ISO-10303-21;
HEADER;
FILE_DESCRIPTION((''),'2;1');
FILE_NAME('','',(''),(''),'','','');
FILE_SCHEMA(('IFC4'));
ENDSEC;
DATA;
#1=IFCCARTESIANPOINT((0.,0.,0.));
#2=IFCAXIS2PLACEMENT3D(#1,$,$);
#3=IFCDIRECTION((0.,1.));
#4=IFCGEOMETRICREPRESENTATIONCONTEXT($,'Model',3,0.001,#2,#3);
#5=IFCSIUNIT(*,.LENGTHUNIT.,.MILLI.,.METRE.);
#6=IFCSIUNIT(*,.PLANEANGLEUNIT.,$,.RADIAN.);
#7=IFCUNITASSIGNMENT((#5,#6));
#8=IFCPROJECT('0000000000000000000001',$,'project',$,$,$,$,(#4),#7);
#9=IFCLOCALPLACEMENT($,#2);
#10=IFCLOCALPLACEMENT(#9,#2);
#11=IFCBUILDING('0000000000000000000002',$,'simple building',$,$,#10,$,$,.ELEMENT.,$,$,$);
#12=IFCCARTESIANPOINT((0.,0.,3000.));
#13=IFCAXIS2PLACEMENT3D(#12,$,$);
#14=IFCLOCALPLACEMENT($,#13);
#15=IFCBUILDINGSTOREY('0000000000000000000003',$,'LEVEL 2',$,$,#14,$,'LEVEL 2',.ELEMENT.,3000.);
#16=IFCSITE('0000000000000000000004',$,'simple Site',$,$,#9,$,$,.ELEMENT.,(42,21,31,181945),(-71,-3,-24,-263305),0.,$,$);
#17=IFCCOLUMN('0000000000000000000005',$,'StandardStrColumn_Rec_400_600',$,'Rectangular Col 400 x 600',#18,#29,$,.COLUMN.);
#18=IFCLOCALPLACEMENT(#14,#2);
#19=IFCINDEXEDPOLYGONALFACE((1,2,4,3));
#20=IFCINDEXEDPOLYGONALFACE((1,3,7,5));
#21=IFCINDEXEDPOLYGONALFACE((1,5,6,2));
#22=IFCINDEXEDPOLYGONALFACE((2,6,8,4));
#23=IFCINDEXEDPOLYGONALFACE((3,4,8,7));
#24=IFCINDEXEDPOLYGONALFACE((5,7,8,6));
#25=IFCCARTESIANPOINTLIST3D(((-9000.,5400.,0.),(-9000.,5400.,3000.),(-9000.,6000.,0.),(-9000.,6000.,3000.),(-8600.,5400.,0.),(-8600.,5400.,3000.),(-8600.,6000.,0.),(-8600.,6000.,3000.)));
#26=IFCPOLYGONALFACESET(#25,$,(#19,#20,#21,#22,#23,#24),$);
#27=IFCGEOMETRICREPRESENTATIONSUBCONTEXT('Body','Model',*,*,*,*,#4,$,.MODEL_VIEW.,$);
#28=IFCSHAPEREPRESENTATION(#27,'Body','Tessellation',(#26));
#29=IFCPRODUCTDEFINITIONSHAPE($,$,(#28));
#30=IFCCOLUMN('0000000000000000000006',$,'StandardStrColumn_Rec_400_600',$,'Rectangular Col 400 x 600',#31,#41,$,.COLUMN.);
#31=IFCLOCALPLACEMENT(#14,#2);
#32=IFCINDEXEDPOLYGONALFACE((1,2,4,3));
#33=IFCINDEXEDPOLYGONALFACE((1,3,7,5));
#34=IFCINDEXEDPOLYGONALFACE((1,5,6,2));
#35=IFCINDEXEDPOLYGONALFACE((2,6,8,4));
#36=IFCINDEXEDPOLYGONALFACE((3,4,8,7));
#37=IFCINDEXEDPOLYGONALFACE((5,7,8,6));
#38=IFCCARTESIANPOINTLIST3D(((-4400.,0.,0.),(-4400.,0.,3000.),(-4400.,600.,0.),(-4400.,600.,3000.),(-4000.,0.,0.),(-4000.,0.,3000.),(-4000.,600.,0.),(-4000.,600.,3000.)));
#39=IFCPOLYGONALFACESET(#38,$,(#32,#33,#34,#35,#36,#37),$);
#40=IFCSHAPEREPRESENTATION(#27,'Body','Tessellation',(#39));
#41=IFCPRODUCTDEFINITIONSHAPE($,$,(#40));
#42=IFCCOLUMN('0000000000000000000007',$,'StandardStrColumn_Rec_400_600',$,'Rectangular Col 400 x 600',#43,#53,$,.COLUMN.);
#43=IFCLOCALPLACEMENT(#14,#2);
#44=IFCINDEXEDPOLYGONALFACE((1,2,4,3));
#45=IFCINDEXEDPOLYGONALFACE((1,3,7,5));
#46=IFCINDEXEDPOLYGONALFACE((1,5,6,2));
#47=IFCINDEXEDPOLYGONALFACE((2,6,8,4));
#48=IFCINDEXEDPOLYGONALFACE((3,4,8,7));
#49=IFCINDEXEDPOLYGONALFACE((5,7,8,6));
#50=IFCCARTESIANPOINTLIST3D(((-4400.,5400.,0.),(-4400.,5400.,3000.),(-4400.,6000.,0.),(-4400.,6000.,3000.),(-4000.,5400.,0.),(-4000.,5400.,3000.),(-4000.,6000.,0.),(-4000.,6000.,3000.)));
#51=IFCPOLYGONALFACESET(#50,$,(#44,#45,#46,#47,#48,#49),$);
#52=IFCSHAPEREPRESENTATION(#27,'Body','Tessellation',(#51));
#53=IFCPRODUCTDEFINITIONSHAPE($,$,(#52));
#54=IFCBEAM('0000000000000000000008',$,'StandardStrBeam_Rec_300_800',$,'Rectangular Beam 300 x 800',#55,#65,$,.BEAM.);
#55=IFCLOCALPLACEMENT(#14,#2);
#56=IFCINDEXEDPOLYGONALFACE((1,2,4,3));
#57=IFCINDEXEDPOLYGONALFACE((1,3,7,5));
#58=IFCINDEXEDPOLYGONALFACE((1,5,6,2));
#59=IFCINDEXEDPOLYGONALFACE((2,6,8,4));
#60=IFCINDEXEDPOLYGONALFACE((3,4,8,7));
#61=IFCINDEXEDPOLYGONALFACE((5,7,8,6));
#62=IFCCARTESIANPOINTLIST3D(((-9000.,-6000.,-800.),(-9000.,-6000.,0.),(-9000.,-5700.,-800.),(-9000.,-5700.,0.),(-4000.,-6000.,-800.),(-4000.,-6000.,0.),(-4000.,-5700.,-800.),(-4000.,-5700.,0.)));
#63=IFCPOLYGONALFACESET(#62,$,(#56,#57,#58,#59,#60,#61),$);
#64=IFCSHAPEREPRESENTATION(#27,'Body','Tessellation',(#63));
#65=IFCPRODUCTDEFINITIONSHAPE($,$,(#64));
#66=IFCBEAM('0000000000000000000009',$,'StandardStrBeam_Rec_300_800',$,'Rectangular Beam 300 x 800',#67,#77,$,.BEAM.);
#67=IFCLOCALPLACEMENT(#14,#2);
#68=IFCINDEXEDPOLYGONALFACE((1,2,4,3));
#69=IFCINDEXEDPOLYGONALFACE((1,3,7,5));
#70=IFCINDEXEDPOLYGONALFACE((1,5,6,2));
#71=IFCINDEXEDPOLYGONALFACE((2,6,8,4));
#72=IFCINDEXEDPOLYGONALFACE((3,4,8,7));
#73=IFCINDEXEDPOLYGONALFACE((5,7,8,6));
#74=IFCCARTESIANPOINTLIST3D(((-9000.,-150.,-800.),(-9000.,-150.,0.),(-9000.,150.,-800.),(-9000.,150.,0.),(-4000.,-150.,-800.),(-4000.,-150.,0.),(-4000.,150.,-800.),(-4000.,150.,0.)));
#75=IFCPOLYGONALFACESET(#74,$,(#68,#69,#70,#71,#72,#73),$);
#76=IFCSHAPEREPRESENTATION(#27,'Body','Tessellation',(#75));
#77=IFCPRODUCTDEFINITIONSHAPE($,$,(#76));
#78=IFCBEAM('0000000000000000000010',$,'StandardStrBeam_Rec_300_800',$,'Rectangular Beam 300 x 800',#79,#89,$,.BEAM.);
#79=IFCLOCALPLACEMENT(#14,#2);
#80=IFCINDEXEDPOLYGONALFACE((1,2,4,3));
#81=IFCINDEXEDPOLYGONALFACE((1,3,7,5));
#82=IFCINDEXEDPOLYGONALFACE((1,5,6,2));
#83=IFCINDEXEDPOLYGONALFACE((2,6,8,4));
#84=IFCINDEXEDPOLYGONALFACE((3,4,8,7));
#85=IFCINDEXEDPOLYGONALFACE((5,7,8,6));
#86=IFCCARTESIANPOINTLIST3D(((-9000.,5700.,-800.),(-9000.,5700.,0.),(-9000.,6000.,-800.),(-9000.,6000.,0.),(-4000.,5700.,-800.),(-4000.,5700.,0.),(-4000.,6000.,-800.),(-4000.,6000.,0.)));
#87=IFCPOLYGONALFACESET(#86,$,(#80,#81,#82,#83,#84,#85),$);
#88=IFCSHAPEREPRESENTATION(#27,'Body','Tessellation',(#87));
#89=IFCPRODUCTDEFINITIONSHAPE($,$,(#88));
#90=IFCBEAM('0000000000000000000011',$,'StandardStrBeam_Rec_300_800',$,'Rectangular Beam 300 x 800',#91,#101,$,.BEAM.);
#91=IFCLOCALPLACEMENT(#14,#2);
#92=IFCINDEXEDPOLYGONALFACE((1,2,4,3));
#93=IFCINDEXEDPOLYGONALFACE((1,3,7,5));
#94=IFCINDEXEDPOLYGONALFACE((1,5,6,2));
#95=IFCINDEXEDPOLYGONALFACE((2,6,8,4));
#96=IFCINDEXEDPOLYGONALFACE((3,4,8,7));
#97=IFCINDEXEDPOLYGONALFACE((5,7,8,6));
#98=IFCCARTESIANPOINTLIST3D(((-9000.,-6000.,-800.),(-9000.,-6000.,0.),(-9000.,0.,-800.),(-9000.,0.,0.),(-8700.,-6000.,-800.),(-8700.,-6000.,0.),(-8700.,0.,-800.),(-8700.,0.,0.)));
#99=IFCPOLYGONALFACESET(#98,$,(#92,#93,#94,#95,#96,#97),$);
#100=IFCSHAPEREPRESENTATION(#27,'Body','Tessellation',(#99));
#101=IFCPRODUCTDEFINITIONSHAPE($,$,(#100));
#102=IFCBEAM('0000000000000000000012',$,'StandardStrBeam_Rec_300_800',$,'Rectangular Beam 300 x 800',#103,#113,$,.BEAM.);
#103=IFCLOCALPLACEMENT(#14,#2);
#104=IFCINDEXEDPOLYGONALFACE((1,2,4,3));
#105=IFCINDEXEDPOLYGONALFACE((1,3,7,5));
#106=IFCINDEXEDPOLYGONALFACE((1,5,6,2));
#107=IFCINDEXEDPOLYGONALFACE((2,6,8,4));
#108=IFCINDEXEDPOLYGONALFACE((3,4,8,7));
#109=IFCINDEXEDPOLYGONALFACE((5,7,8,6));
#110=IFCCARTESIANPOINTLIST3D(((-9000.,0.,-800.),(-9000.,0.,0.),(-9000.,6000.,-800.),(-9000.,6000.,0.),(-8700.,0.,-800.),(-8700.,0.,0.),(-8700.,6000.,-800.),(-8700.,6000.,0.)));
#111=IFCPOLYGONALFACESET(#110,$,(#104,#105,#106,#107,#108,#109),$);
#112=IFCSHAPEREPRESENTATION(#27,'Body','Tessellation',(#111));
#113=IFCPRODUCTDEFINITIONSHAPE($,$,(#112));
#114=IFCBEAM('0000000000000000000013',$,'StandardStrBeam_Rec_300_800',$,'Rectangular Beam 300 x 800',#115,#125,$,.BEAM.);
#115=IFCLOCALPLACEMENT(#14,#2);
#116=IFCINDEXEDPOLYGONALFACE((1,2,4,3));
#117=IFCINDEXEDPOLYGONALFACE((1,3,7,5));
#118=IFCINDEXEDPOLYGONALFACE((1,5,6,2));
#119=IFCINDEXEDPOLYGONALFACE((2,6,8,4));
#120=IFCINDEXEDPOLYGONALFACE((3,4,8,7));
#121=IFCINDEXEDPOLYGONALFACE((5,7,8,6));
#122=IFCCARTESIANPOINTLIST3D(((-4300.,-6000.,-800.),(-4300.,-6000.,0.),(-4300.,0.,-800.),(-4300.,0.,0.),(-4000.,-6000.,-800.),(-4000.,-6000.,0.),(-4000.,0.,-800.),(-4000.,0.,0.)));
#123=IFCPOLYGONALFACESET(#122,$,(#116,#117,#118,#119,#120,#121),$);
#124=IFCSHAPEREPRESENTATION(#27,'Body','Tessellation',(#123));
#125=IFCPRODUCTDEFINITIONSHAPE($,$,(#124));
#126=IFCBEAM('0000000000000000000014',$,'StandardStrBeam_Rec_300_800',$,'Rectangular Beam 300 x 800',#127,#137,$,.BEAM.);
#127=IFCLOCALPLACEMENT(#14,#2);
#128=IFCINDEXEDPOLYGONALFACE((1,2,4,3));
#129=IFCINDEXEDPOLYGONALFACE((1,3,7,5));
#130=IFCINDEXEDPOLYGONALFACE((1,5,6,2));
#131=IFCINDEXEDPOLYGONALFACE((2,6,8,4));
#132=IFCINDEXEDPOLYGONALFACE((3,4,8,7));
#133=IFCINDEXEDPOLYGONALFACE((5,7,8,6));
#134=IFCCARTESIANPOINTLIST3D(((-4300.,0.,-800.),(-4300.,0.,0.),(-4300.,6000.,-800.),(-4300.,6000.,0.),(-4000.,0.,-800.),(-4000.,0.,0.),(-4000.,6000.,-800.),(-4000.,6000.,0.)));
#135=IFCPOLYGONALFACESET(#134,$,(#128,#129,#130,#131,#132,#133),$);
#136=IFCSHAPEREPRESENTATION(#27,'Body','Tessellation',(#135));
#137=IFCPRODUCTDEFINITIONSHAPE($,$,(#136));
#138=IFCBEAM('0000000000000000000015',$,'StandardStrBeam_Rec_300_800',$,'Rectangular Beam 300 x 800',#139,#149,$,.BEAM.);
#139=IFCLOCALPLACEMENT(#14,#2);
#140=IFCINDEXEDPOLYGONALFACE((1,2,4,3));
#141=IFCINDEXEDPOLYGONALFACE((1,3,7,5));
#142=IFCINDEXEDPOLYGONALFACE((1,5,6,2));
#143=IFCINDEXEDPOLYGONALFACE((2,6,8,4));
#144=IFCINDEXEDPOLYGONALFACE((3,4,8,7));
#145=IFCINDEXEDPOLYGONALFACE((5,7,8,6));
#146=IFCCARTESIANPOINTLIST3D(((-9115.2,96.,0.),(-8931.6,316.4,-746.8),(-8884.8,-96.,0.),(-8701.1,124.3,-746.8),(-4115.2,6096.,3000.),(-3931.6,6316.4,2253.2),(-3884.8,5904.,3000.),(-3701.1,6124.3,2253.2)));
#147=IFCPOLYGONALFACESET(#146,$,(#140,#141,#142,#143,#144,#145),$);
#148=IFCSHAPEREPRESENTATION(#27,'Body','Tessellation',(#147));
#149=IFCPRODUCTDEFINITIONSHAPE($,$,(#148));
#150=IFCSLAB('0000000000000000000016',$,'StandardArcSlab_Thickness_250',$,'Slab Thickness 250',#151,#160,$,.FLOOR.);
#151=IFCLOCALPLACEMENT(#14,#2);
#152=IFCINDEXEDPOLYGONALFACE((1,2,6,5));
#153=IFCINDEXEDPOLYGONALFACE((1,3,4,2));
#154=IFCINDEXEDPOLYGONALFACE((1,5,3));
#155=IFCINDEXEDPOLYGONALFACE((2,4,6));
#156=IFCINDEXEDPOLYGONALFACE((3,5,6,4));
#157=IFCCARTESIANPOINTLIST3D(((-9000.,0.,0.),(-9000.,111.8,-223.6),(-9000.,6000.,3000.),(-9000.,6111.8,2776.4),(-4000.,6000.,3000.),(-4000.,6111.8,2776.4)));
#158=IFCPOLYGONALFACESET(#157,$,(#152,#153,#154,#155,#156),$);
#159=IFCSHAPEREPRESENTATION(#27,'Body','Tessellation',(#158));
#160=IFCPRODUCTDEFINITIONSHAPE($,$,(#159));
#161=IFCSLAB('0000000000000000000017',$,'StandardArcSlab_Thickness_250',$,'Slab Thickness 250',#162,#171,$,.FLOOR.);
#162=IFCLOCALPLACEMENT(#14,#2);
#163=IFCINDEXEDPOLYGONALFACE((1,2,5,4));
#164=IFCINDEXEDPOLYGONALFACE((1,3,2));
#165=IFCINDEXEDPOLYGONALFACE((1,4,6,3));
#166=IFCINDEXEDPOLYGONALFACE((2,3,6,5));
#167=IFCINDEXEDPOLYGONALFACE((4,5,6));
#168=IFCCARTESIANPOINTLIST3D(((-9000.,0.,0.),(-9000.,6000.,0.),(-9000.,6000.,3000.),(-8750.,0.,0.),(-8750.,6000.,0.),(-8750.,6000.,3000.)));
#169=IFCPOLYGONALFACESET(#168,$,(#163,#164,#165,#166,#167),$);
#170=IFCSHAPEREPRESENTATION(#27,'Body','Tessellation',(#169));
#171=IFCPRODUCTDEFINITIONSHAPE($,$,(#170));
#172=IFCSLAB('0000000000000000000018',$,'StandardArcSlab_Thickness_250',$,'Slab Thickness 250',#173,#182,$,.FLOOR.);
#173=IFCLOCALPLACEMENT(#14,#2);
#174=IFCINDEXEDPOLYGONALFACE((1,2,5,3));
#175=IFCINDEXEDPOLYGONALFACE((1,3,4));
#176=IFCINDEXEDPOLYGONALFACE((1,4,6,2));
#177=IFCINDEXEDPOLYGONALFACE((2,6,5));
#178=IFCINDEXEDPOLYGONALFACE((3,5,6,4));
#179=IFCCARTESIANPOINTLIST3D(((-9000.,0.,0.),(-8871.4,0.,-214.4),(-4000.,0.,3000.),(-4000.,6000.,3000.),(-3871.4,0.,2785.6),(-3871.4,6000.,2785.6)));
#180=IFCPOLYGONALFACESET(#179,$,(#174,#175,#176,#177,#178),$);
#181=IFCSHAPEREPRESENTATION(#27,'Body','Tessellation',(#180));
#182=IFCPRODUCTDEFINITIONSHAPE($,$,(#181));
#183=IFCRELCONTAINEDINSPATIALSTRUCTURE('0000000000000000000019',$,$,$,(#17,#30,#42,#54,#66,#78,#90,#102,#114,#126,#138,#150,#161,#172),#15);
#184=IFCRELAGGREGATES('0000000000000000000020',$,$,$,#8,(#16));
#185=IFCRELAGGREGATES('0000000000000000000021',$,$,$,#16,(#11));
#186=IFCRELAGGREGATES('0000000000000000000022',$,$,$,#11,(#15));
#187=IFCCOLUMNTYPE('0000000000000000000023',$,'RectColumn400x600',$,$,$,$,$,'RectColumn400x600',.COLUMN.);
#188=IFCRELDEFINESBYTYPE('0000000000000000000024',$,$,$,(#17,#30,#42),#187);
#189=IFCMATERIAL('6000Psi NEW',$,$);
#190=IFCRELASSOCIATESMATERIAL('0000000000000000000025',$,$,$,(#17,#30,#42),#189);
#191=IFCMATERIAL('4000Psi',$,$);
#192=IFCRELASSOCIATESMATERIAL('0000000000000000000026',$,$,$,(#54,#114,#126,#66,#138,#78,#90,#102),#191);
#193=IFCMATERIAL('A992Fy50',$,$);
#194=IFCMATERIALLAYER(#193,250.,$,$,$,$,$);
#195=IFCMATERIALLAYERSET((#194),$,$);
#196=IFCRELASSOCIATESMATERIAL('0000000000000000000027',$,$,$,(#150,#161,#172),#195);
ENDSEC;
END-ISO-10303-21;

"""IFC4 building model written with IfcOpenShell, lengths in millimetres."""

from ifc_helpers import new_model, si_unit, direction, frame, origin, origin_with_axes, origin_2d_with_axis, place, context, subcontext, project, spatial, polyline, rectangle, outline, extrude, material, layer, layer_set, layer_usage, material_profile, profile_set, profile_usage, type_object, element, save


model = new_model("IFC4")

# Units and contexts
model_context = context("Model", 3, precision=0.001, world=origin(), true_north=direction((0.0, 1.0)))
body_context = subcontext(model_context, "Body", "Model", "MODEL_VIEW")
ifc_project = project(units=[si_unit("LENGTHUNIT", "METRE", prefix="MILLI"), si_unit("PLANEANGLEUNIT", "RADIAN")], contexts=[model_context])

# Site, building, storey
site_placement = place(None, origin())
site = spatial("IfcSite", under=ifc_project, at=site_placement, Name="simple Site", CompositionType="ELEMENT", RefLatitude=(42, 21, 31, 181945), RefLongitude=(-71, -3, -24, -263305), RefElevation=0.0)
building_placement = place(site_placement, origin())
building = spatial("IfcBuilding", under=site, at=building_placement, Name="simple building", CompositionType="ELEMENT")
storey_placement = place(None, frame((0.0, 0.0, 3000.0)))
storey = spatial("IfcBuildingStorey", under=building, at=storey_placement, Name="LEVEL 2", LongName="LEVEL 2", CompositionType="ELEMENT", Elevation=3000.0)

# Columns
ifc_material_1 = material(Name="6000Psi NEW")
ifc_material_profile_1 = material_profile(ifc_material_1, rectangle(XDim=400.0, YDim=600.0, at=origin_2d_with_axis()))
ifc_profile_set_1 = profile_set([ifc_material_profile_1])
ifc_profile_usage_1 = profile_usage(ifc_profile_set_1, cardinal=1)
column_type = type_object("IfcColumnType", Name="RectColumn400x600", ElementType="RectColumn400x600", PredefinedType="COLUMN")
column_1_placement = place(None, frame((-8800.0, 5700.0, 3000.0), z_axis=(0.0, 0.0, 1.0), x_axis=(1.0, 0.0, 0.0)))
element("IfcColumn", 1, at=column_1_placement, inside=storey, type_object=column_type, material=ifc_profile_usage_1, Name="StandardStrColumn_Rec_400_600", ObjectType="Rectangular Col 400 x 600", PredefinedType="COLUMN", context=body_context, shape_type="SweptSolid", body=[
    extrude(rectangle(XDim=400.0, YDim=600.0, at=origin_2d_with_axis()), origin_with_axes(), (0.0, 0.0, 1.0), 3000.0),
])
ifc_profile_usage_2 = profile_usage(ifc_profile_set_1, cardinal=9)
column_2_placement = place(None, frame((-4200.0, 300.0, 3000.0), z_axis=(0.0, 0.0, 1.0), x_axis=(1.0, 0.0, 0.0)))
element("IfcColumn", 2, at=column_2_placement, inside=storey, type_object=column_type, material=ifc_profile_usage_2, Name="StandardStrColumn_Rec_400_600", ObjectType="Rectangular Col 400 x 600", PredefinedType="COLUMN", context=body_context, shape_type="SweptSolid", body=[
    extrude(rectangle(XDim=400.0, YDim=600.0, at=origin_2d_with_axis()), origin_with_axes(), (0.0, 0.0, 1.0), 3000.0),
])
ifc_profile_usage_3 = profile_usage(ifc_profile_set_1, cardinal=3)
column_3_placement = place(None, frame((-4200.0, 5700.0, 3000.0), z_axis=(0.0, 0.0, 1.0), x_axis=(1.0, 0.0, 0.0)))
element("IfcColumn", 3, at=column_3_placement, inside=storey, type_object=column_type, material=ifc_profile_usage_3, Name="StandardStrColumn_Rec_400_600", ObjectType="Rectangular Col 400 x 600", PredefinedType="COLUMN", context=body_context, shape_type="SweptSolid", body=[
    extrude(rectangle(XDim=400.0, YDim=600.0, at=origin_2d_with_axis()), origin_with_axes(), (0.0, 0.0, 1.0), 3000.0),
])

# Beams
ifc_material_2 = material(Name="4000Psi")
ifc_material_profile_2 = material_profile(ifc_material_2, rectangle(XDim=300.0, YDim=800.0, at=origin_2d_with_axis()))
ifc_profile_set_2 = profile_set([ifc_material_profile_2])
ifc_profile_usage_4 = profile_usage(ifc_profile_set_2, cardinal=9)
beam_1_placement = place(None, frame((-9000.0, -5850.0, 2600.0), z_axis=(1.0, 0.0, 0.0), x_axis=(0.0, -1.0, 0.0)))
element("IfcBeam", 4, at=beam_1_placement, inside=storey, material=ifc_profile_usage_4, Name="StandardStrBeam_Rec_300_800", ObjectType="Rectangular Beam 300 x 800", PredefinedType="BEAM", context=body_context, shape_type="SweptSolid", body=[
    extrude(rectangle(XDim=300.0, YDim=800.0, at=origin_2d_with_axis()), origin_with_axes(), (0.0, 0.0, 1.0), 5000.0),
])
ifc_profile_usage_5 = profile_usage(ifc_profile_set_2, cardinal=8)
beam_2_placement = place(None, frame((-9000.0, 0.0, 2600.0), z_axis=(1.0, 0.0, 0.0), x_axis=(0.0, -1.0, 0.0)))
element("IfcBeam", 5, at=beam_2_placement, inside=storey, material=ifc_profile_usage_5, Name="StandardStrBeam_Rec_300_800", ObjectType="Rectangular Beam 300 x 800", PredefinedType="BEAM", context=body_context, shape_type="SweptSolid", body=[
    extrude(rectangle(XDim=300.0, YDim=800.0, at=origin_2d_with_axis()), origin_with_axes(), (0.0, 0.0, 1.0), 5000.0),
])
ifc_profile_usage_6 = profile_usage(ifc_profile_set_2, cardinal=7)
beam_3_placement = place(None, frame((-9000.0, 5850.0, 2600.0), z_axis=(1.0, 0.0, 0.0), x_axis=(0.0, -1.0, 0.0)))
element("IfcBeam", 6, at=beam_3_placement, inside=storey, material=ifc_profile_usage_6, Name="StandardStrBeam_Rec_300_800", ObjectType="Rectangular Beam 300 x 800", PredefinedType="BEAM", context=body_context, shape_type="SweptSolid", body=[
    extrude(rectangle(XDim=300.0, YDim=800.0, at=origin_2d_with_axis()), origin_with_axes(), (0.0, 0.0, 1.0), 5000.0),
])
for number, where, z_axis, x_axis, name in (
    (7, (-8850.0, -6000.0, 2600.0), (0.0, 1.0, 0.0), (1.0, 0.0, 0.0), "StandardStrBeam_Rec_300_800"),
    (8, (-8850.0, 0.0, 2600.0), (0.0, 1.0, 0.0), (1.0, 0.0, 0.0), "StandardStrBeam_Rec_300_800"),
):
    element("IfcBeam", number, at=place(None, frame(where, z_axis=z_axis, x_axis=x_axis)), inside=storey, material=ifc_profile_usage_6, Name=name, ObjectType="Rectangular Beam 300 x 800", PredefinedType="BEAM", context=body_context, shape_type="SweptSolid", body=[
        extrude(rectangle(XDim=300.0, YDim=800.0, at=origin_2d_with_axis()), origin_with_axes(), (0.0, 0.0, 1.0), 6000.0),
    ])
for number, where, z_axis, x_axis, name in (
    (9, (-4150.0, -6000.0, 2600.0), (0.0, 1.0, 0.0), (1.0, 0.0, 0.0), "StandardStrBeam_Rec_300_800"),
    (10, (-4150.0, 0.0, 2600.0), (0.0, 1.0, 0.0), (1.0, 0.0, 0.0), "StandardStrBeam_Rec_300_800"),
):
    element("IfcBeam", number, at=place(None, frame(where, z_axis=z_axis, x_axis=x_axis)), inside=storey, material=ifc_profile_usage_4, Name=name, ObjectType="Rectangular Beam 300 x 800", PredefinedType="BEAM", context=body_context, shape_type="SweptSolid", body=[
        extrude(rectangle(XDim=300.0, YDim=800.0, at=origin_2d_with_axis()), origin_with_axes(), (0.0, 0.0, 1.0), 6000.0),
    ])
beam_4_placement = place(None, frame((-8908.2, 110.2, 2626.6), z_axis=(0.597614, 0.717137, 0.358569), x_axis=(0.768221, -0.640184, 0.0)))
element("IfcBeam", 11, at=beam_4_placement, inside=storey, material=ifc_profile_usage_5, Name="StandardStrBeam_Rec_300_800", ObjectType="Rectangular Beam 300 x 800", PredefinedType="BEAM", context=body_context, shape_type="SweptSolid", body=[
    extrude(rectangle(XDim=300.0, YDim=800.0, at=origin_2d_with_axis()), origin_with_axes(), (0.0, 0.0, 1.0), 8366.6),
])

# Slabs
ifc_material_3 = material(Name="A992Fy50")
ifc_layer_1 = layer(ifc_material_3, 250.0)
ifc_layer_set_1 = layer_set([ifc_layer_1])
ifc_layer_usage_1 = layer_usage(ifc_layer_set_1, "AXIS3", "POSITIVE", -250.0)
slab_1_placement = place(None, frame((-9000.0, 6111.8, 5776.4), z_axis=(0.0, -0.447214, 0.894427), x_axis=(0.0, -0.894427, -0.447214)))
element("IfcSlab", 12, at=slab_1_placement, inside=storey, material=ifc_layer_usage_1, Name="StandardArcSlab_Thickness_250", ObjectType="Slab Thickness 250", PredefinedType="FLOOR", context=body_context, shape_type="SweptSolid", body=[
    extrude(outline(polyline([(0.0, 0.0), (6708.2, 0.0), (0.0, 5000.0), (0.0, 0.0)])), origin_with_axes(), (0.0, 0.0, 1.0), 250.0),
])
slab_2_placement = place(None, frame((-8750.0, 6000.0, 3000.0), z_axis=(-1.0, 0.0, 0.0), x_axis=(0.0, -1.0, 0.0)))
element("IfcSlab", 13, at=slab_2_placement, inside=storey, material=ifc_layer_usage_1, Name="StandardArcSlab_Thickness_250", ObjectType="Slab Thickness 250", PredefinedType="FLOOR", context=body_context, shape_type="SweptSolid", body=[
    extrude(outline(polyline([(0.0, 0.0), (6000.0, 0.0), (0.0, 3000.0), (0.0, 0.0)])), origin_with_axes(), (0.0, 0.0, 1.0), 250.0),
])
slab_3_placement = place(None, frame((-8871.4, 0.0, 2785.6), z_axis=(-0.514496, 0.0, 0.857493), x_axis=(0.857493, 0.0, 0.514496)))
element("IfcSlab", 14, at=slab_3_placement, inside=storey, material=ifc_layer_usage_1, Name="StandardArcSlab_Thickness_250", ObjectType="Slab Thickness 250", PredefinedType="FLOOR", context=body_context, shape_type="SweptSolid", body=[
    extrude(outline(polyline([(0.0, 0.0), (5831.0, 0.0), (5831.0, 6000.0), (0.0, 0.0)])), origin_with_axes(), (0.0, 0.0, 1.0), 250.0),
])

save(model, "model.ifc")
